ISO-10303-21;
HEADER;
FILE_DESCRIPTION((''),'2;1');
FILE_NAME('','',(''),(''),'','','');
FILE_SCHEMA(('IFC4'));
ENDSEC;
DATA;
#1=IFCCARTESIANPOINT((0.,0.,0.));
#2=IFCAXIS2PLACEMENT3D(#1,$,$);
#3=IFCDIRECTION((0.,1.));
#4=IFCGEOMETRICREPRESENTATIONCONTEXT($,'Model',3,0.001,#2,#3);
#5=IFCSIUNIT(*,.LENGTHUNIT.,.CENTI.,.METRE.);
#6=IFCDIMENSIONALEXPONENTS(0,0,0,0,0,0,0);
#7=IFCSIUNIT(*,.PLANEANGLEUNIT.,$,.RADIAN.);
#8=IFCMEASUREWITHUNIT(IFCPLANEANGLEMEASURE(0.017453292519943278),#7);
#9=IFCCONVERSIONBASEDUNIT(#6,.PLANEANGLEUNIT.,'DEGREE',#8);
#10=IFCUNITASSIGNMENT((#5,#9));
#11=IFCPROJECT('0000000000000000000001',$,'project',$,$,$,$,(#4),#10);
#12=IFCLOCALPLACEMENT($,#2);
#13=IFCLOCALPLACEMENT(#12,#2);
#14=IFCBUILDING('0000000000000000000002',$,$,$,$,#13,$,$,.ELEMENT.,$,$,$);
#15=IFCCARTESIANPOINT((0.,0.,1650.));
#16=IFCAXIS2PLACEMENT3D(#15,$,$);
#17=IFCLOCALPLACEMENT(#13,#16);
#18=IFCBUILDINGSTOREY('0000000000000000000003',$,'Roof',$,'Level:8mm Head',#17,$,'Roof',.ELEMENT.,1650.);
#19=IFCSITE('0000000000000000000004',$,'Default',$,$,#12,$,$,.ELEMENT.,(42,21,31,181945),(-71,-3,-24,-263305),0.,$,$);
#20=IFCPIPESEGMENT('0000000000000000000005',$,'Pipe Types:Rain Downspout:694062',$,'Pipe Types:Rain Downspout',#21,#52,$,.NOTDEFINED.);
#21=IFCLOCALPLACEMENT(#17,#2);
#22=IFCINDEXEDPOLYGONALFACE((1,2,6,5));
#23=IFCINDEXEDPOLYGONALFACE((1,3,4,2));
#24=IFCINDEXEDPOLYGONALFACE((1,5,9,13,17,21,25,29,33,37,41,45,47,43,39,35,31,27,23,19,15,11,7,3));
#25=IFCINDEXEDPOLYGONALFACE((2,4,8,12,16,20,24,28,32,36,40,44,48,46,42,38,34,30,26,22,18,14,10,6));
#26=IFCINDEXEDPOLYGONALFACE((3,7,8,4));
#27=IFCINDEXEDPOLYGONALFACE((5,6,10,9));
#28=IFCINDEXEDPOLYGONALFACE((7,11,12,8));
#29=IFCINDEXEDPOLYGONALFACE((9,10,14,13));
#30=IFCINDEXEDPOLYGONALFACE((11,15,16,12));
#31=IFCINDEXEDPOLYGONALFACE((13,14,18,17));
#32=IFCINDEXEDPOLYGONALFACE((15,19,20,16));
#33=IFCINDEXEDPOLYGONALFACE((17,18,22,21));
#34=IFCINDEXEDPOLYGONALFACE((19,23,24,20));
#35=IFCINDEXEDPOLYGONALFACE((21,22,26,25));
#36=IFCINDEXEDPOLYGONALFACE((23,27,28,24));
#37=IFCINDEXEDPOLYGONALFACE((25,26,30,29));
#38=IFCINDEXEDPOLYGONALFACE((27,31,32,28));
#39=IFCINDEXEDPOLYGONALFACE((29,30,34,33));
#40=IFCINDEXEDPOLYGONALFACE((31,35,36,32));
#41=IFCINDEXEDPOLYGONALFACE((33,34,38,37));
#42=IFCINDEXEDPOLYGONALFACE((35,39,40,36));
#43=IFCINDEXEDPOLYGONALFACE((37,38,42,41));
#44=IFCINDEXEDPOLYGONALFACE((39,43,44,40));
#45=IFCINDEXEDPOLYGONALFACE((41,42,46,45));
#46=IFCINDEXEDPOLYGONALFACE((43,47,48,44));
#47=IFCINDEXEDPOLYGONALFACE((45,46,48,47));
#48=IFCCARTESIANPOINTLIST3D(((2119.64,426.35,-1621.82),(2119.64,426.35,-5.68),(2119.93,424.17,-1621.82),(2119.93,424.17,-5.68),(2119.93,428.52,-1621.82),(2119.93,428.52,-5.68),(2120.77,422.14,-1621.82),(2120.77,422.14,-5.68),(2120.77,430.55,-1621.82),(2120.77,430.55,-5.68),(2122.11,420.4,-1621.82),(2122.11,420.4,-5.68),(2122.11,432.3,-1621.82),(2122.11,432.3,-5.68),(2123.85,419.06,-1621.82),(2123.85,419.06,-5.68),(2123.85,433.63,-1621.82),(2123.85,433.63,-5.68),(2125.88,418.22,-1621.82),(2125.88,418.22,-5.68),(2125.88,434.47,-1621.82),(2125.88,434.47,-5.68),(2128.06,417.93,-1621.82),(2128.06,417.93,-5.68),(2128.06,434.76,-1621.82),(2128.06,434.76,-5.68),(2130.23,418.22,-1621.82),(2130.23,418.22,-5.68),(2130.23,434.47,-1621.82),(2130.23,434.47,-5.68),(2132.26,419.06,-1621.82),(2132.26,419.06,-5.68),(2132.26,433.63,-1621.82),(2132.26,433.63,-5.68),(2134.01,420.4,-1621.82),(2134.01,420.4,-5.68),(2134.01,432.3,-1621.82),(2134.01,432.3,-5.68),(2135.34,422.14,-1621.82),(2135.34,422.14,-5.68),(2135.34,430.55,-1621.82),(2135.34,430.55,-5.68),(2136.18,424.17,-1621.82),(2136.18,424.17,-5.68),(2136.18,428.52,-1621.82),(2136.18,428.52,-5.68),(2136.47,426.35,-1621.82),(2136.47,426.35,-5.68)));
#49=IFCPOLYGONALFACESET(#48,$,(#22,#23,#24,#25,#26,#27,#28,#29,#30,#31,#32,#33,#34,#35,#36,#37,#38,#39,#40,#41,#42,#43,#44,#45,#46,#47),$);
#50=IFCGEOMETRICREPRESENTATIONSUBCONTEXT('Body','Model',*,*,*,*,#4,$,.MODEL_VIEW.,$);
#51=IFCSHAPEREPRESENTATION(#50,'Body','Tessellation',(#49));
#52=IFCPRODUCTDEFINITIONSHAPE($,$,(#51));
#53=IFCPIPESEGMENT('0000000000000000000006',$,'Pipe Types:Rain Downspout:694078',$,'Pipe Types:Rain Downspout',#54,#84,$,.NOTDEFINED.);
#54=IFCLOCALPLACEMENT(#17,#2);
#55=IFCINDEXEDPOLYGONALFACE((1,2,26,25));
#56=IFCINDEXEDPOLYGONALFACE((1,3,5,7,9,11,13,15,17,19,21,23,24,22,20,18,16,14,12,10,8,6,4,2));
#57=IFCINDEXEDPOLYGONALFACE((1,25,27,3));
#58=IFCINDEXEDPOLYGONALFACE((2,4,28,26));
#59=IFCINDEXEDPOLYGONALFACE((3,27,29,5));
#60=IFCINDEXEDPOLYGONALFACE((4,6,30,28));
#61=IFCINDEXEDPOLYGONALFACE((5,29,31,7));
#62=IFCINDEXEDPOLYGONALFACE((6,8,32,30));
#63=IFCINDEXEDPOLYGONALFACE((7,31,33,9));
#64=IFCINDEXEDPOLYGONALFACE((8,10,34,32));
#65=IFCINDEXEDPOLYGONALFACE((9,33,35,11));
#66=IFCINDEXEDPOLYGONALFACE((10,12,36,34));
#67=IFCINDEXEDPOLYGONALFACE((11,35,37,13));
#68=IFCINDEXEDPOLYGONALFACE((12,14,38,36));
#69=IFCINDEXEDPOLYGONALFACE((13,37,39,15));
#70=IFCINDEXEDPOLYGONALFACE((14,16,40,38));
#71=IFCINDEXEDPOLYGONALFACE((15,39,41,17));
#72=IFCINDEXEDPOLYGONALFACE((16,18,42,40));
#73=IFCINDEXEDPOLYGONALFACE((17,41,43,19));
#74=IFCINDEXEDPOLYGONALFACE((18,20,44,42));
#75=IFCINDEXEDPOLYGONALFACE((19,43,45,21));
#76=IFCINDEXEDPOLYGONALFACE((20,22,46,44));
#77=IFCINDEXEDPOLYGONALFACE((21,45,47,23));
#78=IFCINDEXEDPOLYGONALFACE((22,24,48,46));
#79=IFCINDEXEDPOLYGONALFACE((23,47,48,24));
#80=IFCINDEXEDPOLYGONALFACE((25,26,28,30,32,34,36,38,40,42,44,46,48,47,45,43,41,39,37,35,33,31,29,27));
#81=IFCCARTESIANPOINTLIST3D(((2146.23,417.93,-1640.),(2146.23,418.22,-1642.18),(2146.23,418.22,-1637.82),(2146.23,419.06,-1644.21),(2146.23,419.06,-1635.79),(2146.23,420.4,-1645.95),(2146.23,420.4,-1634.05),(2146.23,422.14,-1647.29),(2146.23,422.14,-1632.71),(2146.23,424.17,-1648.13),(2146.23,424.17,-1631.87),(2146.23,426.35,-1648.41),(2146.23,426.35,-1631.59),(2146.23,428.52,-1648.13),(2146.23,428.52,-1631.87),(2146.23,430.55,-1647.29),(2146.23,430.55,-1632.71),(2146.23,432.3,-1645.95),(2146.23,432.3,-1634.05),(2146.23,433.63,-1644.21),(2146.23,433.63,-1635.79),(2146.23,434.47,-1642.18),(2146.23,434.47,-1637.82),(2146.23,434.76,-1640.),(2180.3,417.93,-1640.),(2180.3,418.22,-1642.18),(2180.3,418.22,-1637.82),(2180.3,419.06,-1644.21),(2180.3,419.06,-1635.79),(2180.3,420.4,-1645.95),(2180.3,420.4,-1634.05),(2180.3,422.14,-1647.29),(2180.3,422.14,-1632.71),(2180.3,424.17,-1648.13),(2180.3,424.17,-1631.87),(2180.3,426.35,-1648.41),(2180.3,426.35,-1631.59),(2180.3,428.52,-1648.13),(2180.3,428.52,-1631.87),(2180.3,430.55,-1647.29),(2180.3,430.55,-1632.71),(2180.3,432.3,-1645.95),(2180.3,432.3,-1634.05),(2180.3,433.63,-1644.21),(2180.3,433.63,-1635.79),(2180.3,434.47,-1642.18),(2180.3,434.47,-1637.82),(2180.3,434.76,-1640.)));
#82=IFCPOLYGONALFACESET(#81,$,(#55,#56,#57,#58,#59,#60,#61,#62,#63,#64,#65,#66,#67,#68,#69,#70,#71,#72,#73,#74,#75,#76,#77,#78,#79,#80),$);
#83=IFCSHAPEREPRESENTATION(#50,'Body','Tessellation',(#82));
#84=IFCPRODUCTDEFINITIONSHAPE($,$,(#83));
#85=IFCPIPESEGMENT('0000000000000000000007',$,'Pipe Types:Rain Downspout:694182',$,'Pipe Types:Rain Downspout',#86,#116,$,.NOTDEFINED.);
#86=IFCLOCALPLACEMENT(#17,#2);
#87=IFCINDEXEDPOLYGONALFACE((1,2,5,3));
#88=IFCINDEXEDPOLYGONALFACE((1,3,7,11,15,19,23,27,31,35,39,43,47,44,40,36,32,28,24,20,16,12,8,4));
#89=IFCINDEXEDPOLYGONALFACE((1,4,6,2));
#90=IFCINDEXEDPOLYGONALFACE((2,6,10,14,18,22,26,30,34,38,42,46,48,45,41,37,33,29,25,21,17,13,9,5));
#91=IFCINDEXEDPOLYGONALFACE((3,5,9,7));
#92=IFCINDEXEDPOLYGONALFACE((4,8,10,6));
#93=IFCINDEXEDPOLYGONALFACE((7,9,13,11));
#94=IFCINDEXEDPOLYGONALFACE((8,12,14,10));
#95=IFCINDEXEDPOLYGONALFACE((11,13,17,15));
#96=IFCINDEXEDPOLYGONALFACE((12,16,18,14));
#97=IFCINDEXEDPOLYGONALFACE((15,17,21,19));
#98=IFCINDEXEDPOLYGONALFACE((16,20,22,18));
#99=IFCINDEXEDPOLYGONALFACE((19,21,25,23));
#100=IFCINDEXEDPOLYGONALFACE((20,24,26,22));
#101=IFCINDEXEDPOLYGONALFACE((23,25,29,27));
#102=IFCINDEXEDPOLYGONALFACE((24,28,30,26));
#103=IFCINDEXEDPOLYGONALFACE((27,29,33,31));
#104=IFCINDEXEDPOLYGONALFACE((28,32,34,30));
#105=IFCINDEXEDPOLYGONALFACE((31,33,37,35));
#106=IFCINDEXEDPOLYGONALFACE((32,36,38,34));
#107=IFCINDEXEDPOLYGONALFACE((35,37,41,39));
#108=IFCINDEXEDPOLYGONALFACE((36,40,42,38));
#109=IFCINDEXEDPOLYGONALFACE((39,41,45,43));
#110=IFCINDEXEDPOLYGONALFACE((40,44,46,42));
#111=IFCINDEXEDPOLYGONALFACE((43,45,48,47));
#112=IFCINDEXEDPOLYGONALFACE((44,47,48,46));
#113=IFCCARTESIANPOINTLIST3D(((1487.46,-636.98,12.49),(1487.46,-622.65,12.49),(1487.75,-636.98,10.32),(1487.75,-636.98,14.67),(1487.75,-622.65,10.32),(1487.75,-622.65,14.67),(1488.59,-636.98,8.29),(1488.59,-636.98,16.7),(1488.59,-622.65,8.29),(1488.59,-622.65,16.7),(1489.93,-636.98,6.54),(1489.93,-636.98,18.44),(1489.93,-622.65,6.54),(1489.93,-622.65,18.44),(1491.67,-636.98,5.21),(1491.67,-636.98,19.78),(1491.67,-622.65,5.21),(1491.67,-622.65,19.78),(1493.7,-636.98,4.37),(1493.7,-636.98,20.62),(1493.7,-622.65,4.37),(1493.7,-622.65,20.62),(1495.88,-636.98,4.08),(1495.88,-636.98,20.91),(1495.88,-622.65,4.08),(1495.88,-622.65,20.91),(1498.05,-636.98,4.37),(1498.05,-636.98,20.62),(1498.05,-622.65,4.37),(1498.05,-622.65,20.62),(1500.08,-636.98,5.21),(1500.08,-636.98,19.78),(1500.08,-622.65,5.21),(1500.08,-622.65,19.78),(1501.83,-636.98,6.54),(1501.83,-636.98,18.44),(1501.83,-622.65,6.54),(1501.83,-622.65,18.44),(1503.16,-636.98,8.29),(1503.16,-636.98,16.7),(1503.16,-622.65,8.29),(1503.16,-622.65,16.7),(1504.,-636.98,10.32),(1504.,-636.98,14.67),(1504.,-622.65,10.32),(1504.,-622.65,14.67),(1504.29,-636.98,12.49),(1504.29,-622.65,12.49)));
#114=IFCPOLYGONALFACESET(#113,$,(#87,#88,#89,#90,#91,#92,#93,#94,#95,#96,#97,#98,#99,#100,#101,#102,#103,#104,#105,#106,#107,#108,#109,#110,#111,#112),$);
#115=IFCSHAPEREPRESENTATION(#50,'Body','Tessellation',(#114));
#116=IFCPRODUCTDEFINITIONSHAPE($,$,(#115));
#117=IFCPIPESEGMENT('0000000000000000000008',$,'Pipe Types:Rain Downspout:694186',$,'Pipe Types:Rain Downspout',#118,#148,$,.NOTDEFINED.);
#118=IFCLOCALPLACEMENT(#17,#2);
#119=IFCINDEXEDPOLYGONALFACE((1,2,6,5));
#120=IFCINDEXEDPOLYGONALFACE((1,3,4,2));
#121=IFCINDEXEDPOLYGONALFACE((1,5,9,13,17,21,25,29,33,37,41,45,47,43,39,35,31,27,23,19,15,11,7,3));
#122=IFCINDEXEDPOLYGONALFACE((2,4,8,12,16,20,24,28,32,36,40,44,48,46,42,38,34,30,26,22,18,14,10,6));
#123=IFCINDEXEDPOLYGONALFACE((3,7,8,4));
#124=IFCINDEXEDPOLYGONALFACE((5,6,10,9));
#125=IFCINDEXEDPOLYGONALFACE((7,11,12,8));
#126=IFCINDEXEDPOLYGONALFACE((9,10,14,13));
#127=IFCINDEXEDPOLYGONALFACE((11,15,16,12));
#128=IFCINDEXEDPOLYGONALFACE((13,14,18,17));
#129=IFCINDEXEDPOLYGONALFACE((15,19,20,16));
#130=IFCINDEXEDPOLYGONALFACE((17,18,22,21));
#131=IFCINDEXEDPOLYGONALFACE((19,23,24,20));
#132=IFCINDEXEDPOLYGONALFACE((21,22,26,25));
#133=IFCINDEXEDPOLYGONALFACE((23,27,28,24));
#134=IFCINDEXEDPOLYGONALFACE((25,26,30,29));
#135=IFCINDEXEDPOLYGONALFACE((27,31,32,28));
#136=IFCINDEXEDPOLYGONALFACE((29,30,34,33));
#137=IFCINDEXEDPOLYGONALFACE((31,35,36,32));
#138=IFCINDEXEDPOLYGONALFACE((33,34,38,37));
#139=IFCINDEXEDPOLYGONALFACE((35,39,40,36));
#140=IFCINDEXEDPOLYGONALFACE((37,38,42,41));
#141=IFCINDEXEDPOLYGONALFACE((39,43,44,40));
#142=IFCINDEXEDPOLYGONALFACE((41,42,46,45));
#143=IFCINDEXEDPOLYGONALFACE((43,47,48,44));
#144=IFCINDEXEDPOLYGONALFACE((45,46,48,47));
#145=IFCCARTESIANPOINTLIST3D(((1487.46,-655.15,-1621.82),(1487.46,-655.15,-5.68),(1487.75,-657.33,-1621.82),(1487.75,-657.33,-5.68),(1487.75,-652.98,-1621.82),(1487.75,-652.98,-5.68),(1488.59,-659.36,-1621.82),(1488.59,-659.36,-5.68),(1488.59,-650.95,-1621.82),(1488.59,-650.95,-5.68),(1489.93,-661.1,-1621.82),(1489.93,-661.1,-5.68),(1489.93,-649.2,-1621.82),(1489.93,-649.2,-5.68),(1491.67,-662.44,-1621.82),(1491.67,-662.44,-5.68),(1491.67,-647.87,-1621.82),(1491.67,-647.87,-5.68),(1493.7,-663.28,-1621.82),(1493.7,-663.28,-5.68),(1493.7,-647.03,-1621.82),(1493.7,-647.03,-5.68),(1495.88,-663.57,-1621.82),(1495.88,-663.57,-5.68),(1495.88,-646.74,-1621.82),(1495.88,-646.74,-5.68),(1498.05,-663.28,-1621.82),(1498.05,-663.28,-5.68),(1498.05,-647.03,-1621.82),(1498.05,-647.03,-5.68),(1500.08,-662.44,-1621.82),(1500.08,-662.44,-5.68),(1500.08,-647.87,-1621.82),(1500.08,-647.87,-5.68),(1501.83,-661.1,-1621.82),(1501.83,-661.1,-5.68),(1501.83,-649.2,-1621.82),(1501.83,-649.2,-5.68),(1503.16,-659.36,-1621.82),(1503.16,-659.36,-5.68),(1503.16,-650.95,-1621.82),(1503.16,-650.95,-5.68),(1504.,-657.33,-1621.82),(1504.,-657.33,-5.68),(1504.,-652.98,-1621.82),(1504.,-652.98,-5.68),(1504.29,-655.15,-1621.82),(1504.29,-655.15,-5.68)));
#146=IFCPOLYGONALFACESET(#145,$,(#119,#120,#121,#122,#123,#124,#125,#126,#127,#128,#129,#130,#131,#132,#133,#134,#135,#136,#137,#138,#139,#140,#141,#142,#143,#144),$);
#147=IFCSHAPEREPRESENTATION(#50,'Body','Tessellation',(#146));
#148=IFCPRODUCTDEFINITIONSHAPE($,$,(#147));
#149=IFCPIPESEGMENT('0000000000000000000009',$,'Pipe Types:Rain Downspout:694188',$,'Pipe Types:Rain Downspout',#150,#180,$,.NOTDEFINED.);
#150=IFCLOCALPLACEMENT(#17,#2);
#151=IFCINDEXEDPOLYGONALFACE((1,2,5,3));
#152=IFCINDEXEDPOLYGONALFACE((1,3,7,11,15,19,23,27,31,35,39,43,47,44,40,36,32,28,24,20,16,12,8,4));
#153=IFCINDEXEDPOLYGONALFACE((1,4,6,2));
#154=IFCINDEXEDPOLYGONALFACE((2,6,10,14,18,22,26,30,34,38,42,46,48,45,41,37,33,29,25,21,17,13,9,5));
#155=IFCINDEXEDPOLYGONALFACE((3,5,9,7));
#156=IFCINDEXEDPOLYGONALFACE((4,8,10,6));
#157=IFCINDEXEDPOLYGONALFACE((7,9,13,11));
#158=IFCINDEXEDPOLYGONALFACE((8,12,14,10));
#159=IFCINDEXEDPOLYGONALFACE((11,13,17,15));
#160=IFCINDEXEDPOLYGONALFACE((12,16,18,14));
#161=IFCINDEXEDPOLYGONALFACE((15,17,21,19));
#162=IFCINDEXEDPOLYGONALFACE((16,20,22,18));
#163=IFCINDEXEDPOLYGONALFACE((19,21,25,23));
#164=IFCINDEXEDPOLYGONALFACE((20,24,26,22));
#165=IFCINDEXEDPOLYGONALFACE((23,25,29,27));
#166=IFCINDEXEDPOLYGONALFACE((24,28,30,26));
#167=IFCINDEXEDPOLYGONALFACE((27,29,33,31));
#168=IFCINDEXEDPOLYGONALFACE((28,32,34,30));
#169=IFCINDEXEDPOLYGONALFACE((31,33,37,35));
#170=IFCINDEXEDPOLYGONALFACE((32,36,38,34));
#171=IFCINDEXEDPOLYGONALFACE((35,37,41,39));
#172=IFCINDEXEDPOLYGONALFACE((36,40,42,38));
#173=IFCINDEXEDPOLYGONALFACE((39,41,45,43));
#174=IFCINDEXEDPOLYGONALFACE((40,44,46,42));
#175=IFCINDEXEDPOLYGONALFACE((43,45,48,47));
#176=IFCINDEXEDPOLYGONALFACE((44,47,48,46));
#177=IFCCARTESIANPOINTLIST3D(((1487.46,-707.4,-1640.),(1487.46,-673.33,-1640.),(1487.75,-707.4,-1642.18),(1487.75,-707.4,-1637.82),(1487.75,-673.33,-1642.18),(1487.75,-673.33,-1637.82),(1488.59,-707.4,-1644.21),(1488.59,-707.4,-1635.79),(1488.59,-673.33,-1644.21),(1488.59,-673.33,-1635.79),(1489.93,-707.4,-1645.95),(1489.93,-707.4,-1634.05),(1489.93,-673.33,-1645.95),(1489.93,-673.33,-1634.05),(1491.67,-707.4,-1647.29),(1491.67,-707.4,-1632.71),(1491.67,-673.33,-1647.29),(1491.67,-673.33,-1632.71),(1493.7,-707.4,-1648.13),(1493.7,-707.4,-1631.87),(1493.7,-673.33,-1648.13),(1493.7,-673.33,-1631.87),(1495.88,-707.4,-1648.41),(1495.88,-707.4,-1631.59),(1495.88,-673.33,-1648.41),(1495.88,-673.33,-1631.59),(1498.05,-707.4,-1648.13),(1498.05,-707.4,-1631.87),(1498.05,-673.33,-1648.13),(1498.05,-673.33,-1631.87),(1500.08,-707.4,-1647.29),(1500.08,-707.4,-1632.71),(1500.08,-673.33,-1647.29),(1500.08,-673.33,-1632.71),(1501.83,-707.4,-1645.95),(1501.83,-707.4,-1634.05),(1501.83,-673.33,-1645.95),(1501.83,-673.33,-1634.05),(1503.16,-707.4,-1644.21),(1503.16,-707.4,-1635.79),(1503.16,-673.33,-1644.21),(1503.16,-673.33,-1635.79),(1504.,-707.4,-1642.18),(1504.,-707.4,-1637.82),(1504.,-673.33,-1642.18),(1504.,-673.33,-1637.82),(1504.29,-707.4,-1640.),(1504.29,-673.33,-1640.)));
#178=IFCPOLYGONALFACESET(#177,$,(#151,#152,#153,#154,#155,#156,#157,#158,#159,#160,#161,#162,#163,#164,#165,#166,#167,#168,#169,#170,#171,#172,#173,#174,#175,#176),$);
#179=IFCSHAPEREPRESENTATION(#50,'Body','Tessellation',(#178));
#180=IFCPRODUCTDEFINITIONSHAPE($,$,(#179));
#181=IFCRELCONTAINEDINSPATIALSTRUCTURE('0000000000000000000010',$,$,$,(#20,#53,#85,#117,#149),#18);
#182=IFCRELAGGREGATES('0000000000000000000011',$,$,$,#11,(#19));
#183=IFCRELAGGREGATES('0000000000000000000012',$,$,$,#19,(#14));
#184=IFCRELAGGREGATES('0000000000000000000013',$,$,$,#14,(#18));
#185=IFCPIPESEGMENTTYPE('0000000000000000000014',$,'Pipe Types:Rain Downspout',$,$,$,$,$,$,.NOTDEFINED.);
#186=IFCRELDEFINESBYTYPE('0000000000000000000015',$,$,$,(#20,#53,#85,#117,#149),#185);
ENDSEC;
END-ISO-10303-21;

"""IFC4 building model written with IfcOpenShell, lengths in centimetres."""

from ifc_helpers import new_model, entity, si_unit, converted_unit, direction, frame, origin, place, context, subcontext, project, spatial, arc, indexed_curve, outline, extrude, type_object, element, save


model = new_model("IFC4")

# Units and contexts
model_context = context("Model", 3, precision=0.001, world=origin(), true_north=direction((0.0, 1.0)))
body_context = subcontext(model_context, "Body", "Model", "MODEL_VIEW")
ifc_project = project(units=[si_unit("LENGTHUNIT", "METRE", prefix="CENTI"), converted_unit("PLANEANGLEUNIT", "DEGREE", entity("IfcPlaneAngleMeasure", 0.017453292519943278), si_unit("PLANEANGLEUNIT", "RADIAN"), dimensions=[0, 0, 0, 0, 0, 0, 0])], contexts=[model_context])

# Site, building, storey
site_placement = place(None, origin())
site = spatial("IfcSite", under=ifc_project, at=site_placement, Name="Default", CompositionType="ELEMENT", RefLatitude=(42, 21, 31, 181945), RefLongitude=(-71, -3, -24, -263305), RefElevation=0.0)
building_placement = place(site_placement, origin())
building = spatial("IfcBuilding", under=site, at=building_placement, CompositionType="ELEMENT")
storey_placement = place(building_placement, frame((0.0, 0.0, 1650.0)))
storey = spatial("IfcBuildingStorey", under=building, at=storey_placement, Name="Roof", ObjectType="Level:8mm Head", LongName="Roof", CompositionType="ELEMENT", Elevation=1650.0)

# Pipe segments
pipe_segment_type = type_object("IfcPipeSegmentType", Name="Pipe Types:Rain Downspout", PredefinedType="NOTDEFINED")
pipe_segment_1_placement = place(storey_placement, origin())
element("IfcPipeSegment", 1, at=pipe_segment_1_placement, inside=storey, type_object=pipe_segment_type, Name="Pipe Types:Rain Downspout:694062", ObjectType="Pipe Types:Rain Downspout", PredefinedType="NOTDEFINED", context=body_context, shape_type="SweptSolid", body=[
    extrude(outline(indexed_curve([(8.41, 0.0), (5.95, 5.95), (0.0, 8.41), (-5.95, 5.95), (-8.41, 0.0), (-5.95, -5.95), (0.0, -8.41), (5.95, -5.95)], segments=[arc(1, 2, 3), arc(3, 4, 5), arc(5, 6, 7), arc(7, 8, 1)], self_intersect=False)), frame((2128.06, 426.35, -1621.82)), (0.0, 0.0, 1.0), 1616.14),
])
pipe_segment_2_placement = place(storey_placement, origin())
element("IfcPipeSegment", 2, at=pipe_segment_2_placement, inside=storey, type_object=pipe_segment_type, Name="Pipe Types:Rain Downspout:694078", ObjectType="Pipe Types:Rain Downspout", PredefinedType="NOTDEFINED", context=body_context, shape_type="SweptSolid", body=[
    extrude(outline(indexed_curve([(8.41, 0.0), (5.95, 5.95), (0.0, 8.41), (-5.95, 5.95), (-8.41, 0.0), (-5.95, -5.95), (0.0, -8.41), (5.95, -5.95)], segments=[arc(1, 2, 3), arc(3, 4, 5), arc(5, 6, 7), arc(7, 8, 1)], self_intersect=False)), frame((2146.23, 426.35, -1640.0), z_axis=(1.0, 0.0, 0.0), x_axis=(0.0, -1.0, 0.0)), (0.0, 0.0, 1.0), 34.07),
])
pipe_segment_3_placement = place(storey_placement, origin())
element("IfcPipeSegment", 3, at=pipe_segment_3_placement, inside=storey, type_object=pipe_segment_type, Name="Pipe Types:Rain Downspout:694182", ObjectType="Pipe Types:Rain Downspout", PredefinedType="NOTDEFINED", context=body_context, shape_type="SweptSolid", body=[
    extrude(outline(indexed_curve([(8.41, 0.0), (5.95, 5.95), (0.0, 8.41), (-5.95, 5.95), (-8.41, 0.0), (-5.95, -5.95), (0.0, -8.41), (5.95, -5.95)], segments=[arc(1, 2, 3), arc(3, 4, 5), arc(5, 6, 7), arc(7, 8, 1)], self_intersect=False)), frame((1495.88, -636.98, 12.49), z_axis=(0.0, 1.0, 0.0), x_axis=(1.0, 0.0, 0.0)), (0.0, 0.0, 1.0), 14.32),
])
pipe_segment_4_placement = place(storey_placement, origin())
element("IfcPipeSegment", 4, at=pipe_segment_4_placement, inside=storey, type_object=pipe_segment_type, Name="Pipe Types:Rain Downspout:694186", ObjectType="Pipe Types:Rain Downspout", PredefinedType="NOTDEFINED", context=body_context, shape_type="SweptSolid", body=[
    extrude(outline(indexed_curve([(8.41, 0.0), (5.95, 5.95), (0.0, 8.41), (-5.95, 5.95), (-8.41, 0.0), (-5.95, -5.95), (0.0, -8.41), (5.95, -5.95)], segments=[arc(1, 2, 3), arc(3, 4, 5), arc(5, 6, 7), arc(7, 8, 1)], self_intersect=False)), frame((1495.88, -655.15, -1621.82)), (0.0, 0.0, 1.0), 1616.14),
])
pipe_segment_5_placement = place(storey_placement, origin())
element("IfcPipeSegment", 5, at=pipe_segment_5_placement, inside=storey, type_object=pipe_segment_type, Name="Pipe Types:Rain Downspout:694188", ObjectType="Pipe Types:Rain Downspout", PredefinedType="NOTDEFINED", context=body_context, shape_type="SweptSolid", body=[
    extrude(outline(indexed_curve([(8.41, 0.0), (5.95, 5.95), (0.0, 8.41), (-5.95, 5.95), (-8.41, 0.0), (-5.95, -5.95), (0.0, -8.41), (5.95, -5.95)], segments=[arc(1, 2, 3), arc(3, 4, 5), arc(5, 6, 7), arc(7, 8, 1)], self_intersect=False)), frame((1495.88, -707.4, -1640.0), z_axis=(0.0, 1.0, 0.0), x_axis=(-1.0, 0.0, 0.0)), (0.0, 0.0, 1.0), 34.07),
])

save(model, "model.ifc")
